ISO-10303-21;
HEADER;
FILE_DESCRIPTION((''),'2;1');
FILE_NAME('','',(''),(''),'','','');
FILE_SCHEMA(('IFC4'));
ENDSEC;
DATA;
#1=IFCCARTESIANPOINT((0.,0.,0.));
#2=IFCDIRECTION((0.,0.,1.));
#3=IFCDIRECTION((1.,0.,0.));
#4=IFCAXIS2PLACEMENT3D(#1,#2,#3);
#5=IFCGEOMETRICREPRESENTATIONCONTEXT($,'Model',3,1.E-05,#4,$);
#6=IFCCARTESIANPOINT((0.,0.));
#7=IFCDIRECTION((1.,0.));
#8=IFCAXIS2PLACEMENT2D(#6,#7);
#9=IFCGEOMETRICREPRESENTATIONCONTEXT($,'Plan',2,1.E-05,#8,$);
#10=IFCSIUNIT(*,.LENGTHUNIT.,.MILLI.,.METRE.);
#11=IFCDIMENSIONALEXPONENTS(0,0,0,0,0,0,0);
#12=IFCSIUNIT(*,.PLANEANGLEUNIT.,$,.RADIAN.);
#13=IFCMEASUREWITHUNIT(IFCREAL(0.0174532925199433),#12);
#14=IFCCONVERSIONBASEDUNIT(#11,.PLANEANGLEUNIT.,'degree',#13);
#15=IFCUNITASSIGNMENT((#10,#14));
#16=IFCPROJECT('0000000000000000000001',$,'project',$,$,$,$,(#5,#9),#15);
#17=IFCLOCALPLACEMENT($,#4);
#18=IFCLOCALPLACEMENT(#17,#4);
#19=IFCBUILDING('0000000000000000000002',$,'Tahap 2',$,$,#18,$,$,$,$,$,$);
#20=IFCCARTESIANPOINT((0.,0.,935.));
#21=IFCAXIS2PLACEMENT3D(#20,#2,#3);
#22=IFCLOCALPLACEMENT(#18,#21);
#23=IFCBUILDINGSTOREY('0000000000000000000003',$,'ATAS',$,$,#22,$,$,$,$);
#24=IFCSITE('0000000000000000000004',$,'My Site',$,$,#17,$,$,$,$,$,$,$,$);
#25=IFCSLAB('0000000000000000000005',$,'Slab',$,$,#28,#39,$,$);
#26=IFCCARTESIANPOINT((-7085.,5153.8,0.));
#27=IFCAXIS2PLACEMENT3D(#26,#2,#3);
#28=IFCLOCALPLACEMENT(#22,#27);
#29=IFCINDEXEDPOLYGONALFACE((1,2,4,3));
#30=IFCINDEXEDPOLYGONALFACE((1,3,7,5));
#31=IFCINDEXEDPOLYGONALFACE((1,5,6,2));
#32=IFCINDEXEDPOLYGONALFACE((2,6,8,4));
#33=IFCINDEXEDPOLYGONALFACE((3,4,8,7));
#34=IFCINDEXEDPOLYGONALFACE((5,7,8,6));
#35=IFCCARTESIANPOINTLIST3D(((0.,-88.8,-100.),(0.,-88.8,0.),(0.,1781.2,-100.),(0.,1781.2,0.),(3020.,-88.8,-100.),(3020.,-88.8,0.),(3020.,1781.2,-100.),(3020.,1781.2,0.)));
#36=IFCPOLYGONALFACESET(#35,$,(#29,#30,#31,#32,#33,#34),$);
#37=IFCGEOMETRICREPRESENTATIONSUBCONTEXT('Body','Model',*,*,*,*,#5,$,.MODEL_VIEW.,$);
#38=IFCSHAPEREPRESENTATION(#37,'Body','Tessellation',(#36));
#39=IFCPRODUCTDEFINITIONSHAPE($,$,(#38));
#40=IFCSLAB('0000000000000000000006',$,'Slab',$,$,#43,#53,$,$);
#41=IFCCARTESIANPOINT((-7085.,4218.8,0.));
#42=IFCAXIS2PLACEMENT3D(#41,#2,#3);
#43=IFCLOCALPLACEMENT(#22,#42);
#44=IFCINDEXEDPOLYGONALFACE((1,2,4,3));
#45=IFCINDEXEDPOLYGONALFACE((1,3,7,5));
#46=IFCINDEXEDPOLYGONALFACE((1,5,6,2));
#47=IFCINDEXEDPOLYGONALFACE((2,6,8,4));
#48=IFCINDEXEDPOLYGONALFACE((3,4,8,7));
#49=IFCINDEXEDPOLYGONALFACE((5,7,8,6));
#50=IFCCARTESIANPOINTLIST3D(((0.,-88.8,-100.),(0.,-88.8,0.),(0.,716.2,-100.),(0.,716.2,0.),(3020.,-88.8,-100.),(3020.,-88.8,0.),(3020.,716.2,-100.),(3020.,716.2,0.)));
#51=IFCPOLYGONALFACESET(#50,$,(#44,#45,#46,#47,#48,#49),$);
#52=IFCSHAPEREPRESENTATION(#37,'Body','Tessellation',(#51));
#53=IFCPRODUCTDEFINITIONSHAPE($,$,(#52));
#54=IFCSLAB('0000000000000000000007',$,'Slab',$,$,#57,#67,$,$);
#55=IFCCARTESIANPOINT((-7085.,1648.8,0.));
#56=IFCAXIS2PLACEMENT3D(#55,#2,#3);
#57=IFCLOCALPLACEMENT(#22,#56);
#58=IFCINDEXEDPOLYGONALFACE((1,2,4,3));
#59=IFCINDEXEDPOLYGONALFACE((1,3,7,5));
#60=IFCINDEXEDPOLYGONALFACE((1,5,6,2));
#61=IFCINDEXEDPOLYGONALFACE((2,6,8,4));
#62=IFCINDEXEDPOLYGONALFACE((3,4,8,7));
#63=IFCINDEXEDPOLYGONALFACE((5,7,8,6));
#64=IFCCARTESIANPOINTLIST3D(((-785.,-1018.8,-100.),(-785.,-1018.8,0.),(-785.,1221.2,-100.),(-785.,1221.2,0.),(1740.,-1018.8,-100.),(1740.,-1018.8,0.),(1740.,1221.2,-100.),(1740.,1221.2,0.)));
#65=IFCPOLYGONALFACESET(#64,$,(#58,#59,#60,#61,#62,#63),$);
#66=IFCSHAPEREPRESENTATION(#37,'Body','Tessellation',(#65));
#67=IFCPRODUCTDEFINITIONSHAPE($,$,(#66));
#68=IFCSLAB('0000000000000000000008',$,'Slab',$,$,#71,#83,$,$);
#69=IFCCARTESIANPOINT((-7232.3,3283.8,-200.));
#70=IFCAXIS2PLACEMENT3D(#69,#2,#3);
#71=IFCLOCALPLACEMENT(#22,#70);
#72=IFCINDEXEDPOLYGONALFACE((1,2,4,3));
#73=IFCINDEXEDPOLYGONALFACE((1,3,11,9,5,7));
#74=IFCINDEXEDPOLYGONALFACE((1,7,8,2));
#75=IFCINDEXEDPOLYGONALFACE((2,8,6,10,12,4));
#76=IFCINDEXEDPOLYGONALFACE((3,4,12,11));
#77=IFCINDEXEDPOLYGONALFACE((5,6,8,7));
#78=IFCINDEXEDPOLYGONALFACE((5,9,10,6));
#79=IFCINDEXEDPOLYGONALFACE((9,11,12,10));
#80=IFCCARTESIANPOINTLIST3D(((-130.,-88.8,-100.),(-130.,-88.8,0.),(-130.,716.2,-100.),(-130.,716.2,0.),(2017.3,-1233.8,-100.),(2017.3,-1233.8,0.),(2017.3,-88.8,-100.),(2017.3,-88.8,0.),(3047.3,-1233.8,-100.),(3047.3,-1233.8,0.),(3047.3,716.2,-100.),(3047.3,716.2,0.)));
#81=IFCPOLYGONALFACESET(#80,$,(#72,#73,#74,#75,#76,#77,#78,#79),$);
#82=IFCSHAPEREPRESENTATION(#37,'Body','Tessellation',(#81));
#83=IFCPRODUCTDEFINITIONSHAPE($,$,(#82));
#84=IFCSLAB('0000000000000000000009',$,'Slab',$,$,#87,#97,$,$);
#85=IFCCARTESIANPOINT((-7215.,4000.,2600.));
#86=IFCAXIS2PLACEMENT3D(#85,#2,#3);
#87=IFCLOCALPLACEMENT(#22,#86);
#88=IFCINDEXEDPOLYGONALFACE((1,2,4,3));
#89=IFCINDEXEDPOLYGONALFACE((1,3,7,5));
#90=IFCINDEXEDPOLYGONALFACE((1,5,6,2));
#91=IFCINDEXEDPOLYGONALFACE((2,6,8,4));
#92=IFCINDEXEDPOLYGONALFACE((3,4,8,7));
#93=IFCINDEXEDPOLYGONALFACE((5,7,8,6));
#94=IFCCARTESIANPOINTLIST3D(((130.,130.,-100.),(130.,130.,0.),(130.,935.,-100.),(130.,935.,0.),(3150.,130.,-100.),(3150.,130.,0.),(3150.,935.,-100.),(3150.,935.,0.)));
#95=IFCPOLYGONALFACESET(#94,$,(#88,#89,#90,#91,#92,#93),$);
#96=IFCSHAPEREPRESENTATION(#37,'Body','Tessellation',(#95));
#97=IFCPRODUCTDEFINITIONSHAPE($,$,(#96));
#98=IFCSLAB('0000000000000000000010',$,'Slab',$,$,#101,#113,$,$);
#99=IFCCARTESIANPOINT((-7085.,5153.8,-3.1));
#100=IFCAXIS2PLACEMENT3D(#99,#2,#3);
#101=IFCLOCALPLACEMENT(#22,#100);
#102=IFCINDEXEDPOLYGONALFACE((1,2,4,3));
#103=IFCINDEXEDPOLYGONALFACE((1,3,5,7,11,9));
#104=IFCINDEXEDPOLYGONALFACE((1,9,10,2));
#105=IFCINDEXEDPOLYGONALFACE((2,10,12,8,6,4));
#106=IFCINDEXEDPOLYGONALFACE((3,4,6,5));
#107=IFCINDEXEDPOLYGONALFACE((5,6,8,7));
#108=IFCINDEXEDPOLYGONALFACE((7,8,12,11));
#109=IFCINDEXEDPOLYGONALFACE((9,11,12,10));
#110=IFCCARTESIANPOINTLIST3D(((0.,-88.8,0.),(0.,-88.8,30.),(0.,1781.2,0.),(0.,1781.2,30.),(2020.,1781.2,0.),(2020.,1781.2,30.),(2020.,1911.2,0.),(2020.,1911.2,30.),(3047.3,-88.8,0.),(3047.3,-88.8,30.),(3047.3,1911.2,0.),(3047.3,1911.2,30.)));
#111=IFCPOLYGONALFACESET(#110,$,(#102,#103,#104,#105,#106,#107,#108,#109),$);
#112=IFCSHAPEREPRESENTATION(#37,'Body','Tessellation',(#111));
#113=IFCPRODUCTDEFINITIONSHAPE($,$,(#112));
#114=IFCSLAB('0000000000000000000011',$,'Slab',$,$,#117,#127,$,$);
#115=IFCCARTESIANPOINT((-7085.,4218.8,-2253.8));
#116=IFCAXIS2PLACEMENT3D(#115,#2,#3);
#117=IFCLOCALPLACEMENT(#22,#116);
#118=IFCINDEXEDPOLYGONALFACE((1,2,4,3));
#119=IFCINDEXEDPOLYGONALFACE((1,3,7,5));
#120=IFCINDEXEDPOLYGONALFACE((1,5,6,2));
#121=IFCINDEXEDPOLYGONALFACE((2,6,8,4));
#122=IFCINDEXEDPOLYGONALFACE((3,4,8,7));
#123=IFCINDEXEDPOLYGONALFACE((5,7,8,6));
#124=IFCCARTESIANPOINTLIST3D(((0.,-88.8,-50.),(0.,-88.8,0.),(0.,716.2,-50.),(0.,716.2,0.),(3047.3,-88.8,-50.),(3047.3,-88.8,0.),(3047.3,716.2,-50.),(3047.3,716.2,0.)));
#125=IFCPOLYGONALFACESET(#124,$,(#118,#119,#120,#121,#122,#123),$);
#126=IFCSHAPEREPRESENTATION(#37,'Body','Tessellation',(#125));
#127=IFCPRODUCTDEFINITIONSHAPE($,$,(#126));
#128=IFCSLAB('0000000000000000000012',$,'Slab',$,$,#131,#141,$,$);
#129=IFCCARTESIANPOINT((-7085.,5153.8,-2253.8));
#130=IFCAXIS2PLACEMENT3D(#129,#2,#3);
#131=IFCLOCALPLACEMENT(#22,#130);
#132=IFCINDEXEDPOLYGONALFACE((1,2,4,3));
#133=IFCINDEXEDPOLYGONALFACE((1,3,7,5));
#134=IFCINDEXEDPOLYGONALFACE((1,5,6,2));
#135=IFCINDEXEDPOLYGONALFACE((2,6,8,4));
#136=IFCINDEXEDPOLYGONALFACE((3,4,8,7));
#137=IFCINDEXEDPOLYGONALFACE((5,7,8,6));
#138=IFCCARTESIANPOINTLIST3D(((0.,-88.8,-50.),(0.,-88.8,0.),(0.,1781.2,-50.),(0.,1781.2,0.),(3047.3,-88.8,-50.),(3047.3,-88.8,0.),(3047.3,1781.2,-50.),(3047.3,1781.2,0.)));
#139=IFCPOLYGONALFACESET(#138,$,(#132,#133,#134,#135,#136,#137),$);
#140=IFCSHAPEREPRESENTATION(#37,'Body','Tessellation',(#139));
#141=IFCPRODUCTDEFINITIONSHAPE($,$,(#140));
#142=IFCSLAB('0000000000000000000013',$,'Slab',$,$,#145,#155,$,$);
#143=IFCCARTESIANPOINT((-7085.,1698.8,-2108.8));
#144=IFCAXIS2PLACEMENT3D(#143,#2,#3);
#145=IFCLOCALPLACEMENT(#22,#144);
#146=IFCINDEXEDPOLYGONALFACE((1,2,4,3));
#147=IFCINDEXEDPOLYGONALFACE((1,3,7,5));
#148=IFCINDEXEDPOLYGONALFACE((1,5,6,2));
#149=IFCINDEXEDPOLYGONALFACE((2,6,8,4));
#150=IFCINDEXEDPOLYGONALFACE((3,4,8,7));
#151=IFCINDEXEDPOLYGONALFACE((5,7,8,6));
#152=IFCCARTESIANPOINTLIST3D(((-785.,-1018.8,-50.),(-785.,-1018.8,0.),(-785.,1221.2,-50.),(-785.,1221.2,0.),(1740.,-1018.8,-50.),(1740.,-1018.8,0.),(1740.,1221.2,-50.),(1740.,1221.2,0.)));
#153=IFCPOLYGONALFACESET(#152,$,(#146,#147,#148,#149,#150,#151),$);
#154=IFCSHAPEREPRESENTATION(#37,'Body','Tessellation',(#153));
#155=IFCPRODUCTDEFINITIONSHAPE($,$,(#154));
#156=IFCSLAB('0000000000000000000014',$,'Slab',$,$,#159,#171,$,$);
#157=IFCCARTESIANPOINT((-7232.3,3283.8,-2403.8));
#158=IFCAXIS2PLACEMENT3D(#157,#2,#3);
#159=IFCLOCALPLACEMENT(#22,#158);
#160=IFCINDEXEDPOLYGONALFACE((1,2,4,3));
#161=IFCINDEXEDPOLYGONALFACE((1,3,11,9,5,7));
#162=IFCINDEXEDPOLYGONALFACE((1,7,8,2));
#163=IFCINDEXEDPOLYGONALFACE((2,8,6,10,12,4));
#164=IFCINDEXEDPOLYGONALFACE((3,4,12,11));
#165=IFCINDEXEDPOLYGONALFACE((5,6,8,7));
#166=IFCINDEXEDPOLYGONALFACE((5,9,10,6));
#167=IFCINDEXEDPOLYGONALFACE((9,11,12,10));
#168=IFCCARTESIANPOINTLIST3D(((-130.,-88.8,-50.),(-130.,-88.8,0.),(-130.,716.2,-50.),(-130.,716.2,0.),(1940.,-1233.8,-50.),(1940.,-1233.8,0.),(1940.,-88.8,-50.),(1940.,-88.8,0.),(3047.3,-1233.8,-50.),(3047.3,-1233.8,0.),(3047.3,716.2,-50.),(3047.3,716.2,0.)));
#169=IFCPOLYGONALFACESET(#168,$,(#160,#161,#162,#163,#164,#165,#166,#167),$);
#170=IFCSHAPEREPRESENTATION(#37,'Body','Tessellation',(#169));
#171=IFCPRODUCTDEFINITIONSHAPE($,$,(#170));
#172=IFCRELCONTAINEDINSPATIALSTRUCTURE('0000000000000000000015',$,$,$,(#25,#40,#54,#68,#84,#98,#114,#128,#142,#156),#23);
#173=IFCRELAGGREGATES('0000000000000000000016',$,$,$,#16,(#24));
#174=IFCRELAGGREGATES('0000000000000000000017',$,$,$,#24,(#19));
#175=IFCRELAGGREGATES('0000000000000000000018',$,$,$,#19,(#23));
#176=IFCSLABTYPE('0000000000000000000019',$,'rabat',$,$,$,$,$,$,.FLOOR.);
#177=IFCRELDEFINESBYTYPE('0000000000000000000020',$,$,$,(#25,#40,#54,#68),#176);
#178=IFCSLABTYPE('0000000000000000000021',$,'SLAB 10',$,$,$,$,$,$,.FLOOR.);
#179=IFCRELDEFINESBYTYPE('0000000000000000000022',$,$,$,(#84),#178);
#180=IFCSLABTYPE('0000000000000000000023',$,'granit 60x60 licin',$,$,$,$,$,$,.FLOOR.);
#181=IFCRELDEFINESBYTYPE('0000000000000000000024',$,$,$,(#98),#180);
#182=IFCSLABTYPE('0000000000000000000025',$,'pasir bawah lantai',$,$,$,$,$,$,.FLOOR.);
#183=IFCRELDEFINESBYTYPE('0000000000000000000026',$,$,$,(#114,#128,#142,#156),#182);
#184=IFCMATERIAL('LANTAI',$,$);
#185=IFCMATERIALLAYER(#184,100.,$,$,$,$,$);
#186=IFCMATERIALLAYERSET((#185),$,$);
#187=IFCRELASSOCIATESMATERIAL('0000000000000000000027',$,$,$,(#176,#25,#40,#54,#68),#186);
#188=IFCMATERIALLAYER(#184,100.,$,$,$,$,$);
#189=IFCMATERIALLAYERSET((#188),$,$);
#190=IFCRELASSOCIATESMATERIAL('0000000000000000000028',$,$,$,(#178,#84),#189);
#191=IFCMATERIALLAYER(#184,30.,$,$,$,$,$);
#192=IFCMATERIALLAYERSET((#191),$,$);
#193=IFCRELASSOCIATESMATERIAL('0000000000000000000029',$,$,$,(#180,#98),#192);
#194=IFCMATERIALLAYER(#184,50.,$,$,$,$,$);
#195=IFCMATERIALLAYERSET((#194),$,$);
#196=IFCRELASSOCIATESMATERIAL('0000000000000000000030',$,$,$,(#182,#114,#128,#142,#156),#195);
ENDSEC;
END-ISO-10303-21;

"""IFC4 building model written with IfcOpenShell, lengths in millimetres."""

from ifc_helpers import new_model, entity, si_unit, converted_unit, frame, origin_with_axes, origin_2d_with_axis, place, context, subcontext, project, spatial, indexed_curve, outline, extrude, material, layer, layer_set, layer_usage, type_object, element, save


model = new_model("IFC4")

# Units and contexts
model_context = context("Model", 3, precision=1e-05, world=origin_with_axes())
plan_context = context("Plan", 2, precision=1e-05, world=origin_2d_with_axis())
body_context_1 = subcontext(model_context, "Body", "Model", "MODEL_VIEW")
ifc_project = project(units=[si_unit("LENGTHUNIT", "METRE", prefix="MILLI"), converted_unit("PLANEANGLEUNIT", "degree", entity("IfcReal", 0.0174532925199433), si_unit("PLANEANGLEUNIT", "RADIAN"), dimensions=[0, 0, 0, 0, 0, 0, 0])], contexts=[model_context, plan_context])

# Site, building, storey
site_placement = place(None, origin_with_axes())
site = spatial("IfcSite", under=ifc_project, at=site_placement, Name="My Site")
building_placement = place(site_placement, origin_with_axes())
building = spatial("IfcBuilding", under=site, at=building_placement, Name="Tahap 2")
storey_placement = place(building_placement, frame((0.0, 0.0, 935.0), z_axis=(0.0, 0.0, 1.0), x_axis=(1.0, 0.0, 0.0)))
storey = spatial("IfcBuildingStorey", under=building, at=storey_placement, Name="ATAS")

# Slabs
ifc_material_1 = material(Name="LANTAI")
ifc_layer_1 = layer(ifc_material_1, 100.0)
ifc_layer_set_1 = layer_set([ifc_layer_1])
ifc_layer_usage_1 = layer_usage(ifc_layer_set_1, "AXIS3", "NEGATIVE", 0.0)
slab_type_1 = type_object("IfcSlabType", Name="rabat", PredefinedType="FLOOR", material=ifc_layer_set_1)
slab_1_placement = place(storey_placement, frame((-7085.0, 5153.8, 0.0), z_axis=(0.0, 0.0, 1.0), x_axis=(1.0, 0.0, 0.0)))
element("IfcSlab", 1, at=slab_1_placement, inside=storey, type_object=slab_type_1, material=ifc_layer_usage_1, Name="Slab", context=body_context_1, shape_type="SweptSolid", body=[
    extrude(outline(indexed_curve([(0.0, -88.8), (3020.0, -88.8), (3020.0, 1781.2), (0.0, 1781.2), (0.0, -88.8)])), None, (0.0, 0.0, -1.0), 100.0),
])
ifc_layer_usage_2 = layer_usage(ifc_layer_set_1, "AXIS3", "NEGATIVE", 0.0)
slab_2_placement = place(storey_placement, frame((-7085.0, 4218.8, 0.0), z_axis=(0.0, 0.0, 1.0), x_axis=(1.0, 0.0, 0.0)))
element("IfcSlab", 2, at=slab_2_placement, inside=storey, type_object=slab_type_1, material=ifc_layer_usage_2, Name="Slab", context=body_context_1, shape_type="SweptSolid", body=[
    extrude(outline(indexed_curve([(3020.0, 716.2), (0.0, 716.2), (0.0, -88.8), (3020.0, -88.8), (3020.0, 716.2)])), None, (0.0, 0.0, -1.0), 100.0),
])
ifc_layer_usage_3 = layer_usage(ifc_layer_set_1, "AXIS3", "NEGATIVE", 0.0)
slab_3_placement = place(storey_placement, frame((-7085.0, 1648.8, 0.0), z_axis=(0.0, 0.0, 1.0), x_axis=(1.0, 0.0, 0.0)))
element("IfcSlab", 3, at=slab_3_placement, inside=storey, type_object=slab_type_1, material=ifc_layer_usage_3, Name="Slab", context=body_context_1, shape_type="SweptSolid", body=[
    extrude(outline(indexed_curve([(-785.0, 1221.2), (1740.0, 1221.2), (1740.0, -1018.8), (-785.0, -1018.8), (-785.0, 1221.2)])), None, (0.0, 0.0, -1.0), 100.0),
])
ifc_layer_usage_4 = layer_usage(ifc_layer_set_1, "AXIS3", "NEGATIVE", 0.0)
slab_4_placement = place(storey_placement, frame((-7232.3, 3283.8, -200.0), z_axis=(0.0, 0.0, 1.0), x_axis=(1.0, 0.0, 0.0)))
element("IfcSlab", 4, at=slab_4_placement, inside=storey, type_object=slab_type_1, material=ifc_layer_usage_4, Name="Slab", context=body_context_1, shape_type="SweptSolid", body=[
    extrude(outline(indexed_curve([(3047.3, -1233.8), (3047.3, 716.2), (-130.0, 716.2), (-130.0, -88.8), (2017.3, -88.8), (2017.3, -1233.8), (3047.3, -1233.8)])), None, (0.0, 0.0, -1.0), 100.0),
])
ifc_layer_2 = layer(ifc_material_1, 100.0)
ifc_layer_set_2 = layer_set([ifc_layer_2])
ifc_layer_usage_5 = layer_usage(ifc_layer_set_2, "AXIS3", "NEGATIVE", 0.0)
slab_type_2 = type_object("IfcSlabType", Name="SLAB 10", PredefinedType="FLOOR", material=ifc_layer_set_2)
slab_5_placement = place(storey_placement, frame((-7215.0, 4000.0, 2600.0), z_axis=(0.0, 0.0, 1.0), x_axis=(1.0, 0.0, 0.0)))
element("IfcSlab", 5, at=slab_5_placement, inside=storey, type_object=slab_type_2, material=ifc_layer_usage_5, Name="Slab", context=body_context_1, shape_type="SweptSolid", body=[
    extrude(outline(indexed_curve([(130.0, 935.0), (3150.0, 935.0), (3150.0, 130.0), (130.0, 130.0), (130.0, 935.0)])), None, (0.0, 0.0, -1.0), 100.0),
])
ifc_layer_3 = layer(ifc_material_1, 30.0)
ifc_layer_set_3 = layer_set([ifc_layer_3])
ifc_layer_usage_6 = layer_usage(ifc_layer_set_3, "AXIS3", "POSITIVE", 0.0)
slab_type_3 = type_object("IfcSlabType", Name="granit 60x60 licin", PredefinedType="FLOOR", material=ifc_layer_set_3)
slab_6_placement = place(storey_placement, frame((-7085.0, 5153.8, -3.1), z_axis=(0.0, 0.0, 1.0), x_axis=(1.0, 0.0, 0.0)))
element("IfcSlab", 6, at=slab_6_placement, inside=storey, type_object=slab_type_3, material=ifc_layer_usage_6, Name="Slab", context=body_context_1, shape_type="SweptSolid", body=[
    extrude(outline(indexed_curve([(2020.0, 1781.2), (2020.0, 1911.2), (3047.3, 1911.2), (3047.3, -88.8), (0.0, -88.8), (0.0, 1781.2), (2020.0, 1781.2)])), None, (0.0, 0.0, 1.0), 30.0),
])
ifc_layer_4 = layer(ifc_material_1, 50.0)
ifc_layer_set_4 = layer_set([ifc_layer_4])
ifc_layer_usage_7 = layer_usage(ifc_layer_set_4, "AXIS3", "POSITIVE", -50.0)
slab_type_4 = type_object("IfcSlabType", Name="pasir bawah lantai", PredefinedType="FLOOR", material=ifc_layer_set_4)
slab_7_placement = place(storey_placement, frame((-7085.0, 4218.8, -2253.8), z_axis=(0.0, 0.0, 1.0), x_axis=(1.0, 0.0, 0.0)))
element("IfcSlab", 7, at=slab_7_placement, inside=storey, type_object=slab_type_4, material=ifc_layer_usage_7, Name="Slab", context=body_context_1, shape_type="SweptSolid", body=[
    extrude(outline(indexed_curve([(3047.3, -88.8), (0.0, -88.8), (0.0, 716.2), (3047.3, 716.2), (3047.3, -88.8)])), frame((0.0, 0.0, -50.0), z_axis=(0.0, 0.0, 1.0), x_axis=(1.0, 0.0, 0.0)), (0.0, 0.0, 1.0), 50.0),
])
ifc_layer_usage_8 = layer_usage(ifc_layer_set_4, "AXIS3", "POSITIVE", -50.0)
slab_8_placement = place(storey_placement, frame((-7085.0, 5153.8, -2253.8), z_axis=(0.0, 0.0, 1.0), x_axis=(1.0, 0.0, 0.0)))
element("IfcSlab", 8, at=slab_8_placement, inside=storey, type_object=slab_type_4, material=ifc_layer_usage_8, Name="Slab", context=body_context_1, shape_type="SweptSolid", body=[
    extrude(outline(indexed_curve([(0.0, -88.8), (3047.3, -88.8), (3047.3, 1781.2), (0.0, 1781.2), (0.0, -88.8)])), frame((0.0, 0.0, -50.0), z_axis=(0.0, 0.0, 1.0), x_axis=(1.0, 0.0, 0.0)), (0.0, 0.0, 1.0), 50.0),
])
ifc_layer_usage_9 = layer_usage(ifc_layer_set_4, "AXIS3", "POSITIVE", -50.0)
slab_9_placement = place(storey_placement, frame((-7085.0, 1698.8, -2108.8), z_axis=(0.0, 0.0, 1.0), x_axis=(1.0, 0.0, 0.0)))
element("IfcSlab", 9, at=slab_9_placement, inside=storey, type_object=slab_type_4, material=ifc_layer_usage_9, Name="Slab", context=body_context_1, shape_type="SweptSolid", body=[
    extrude(outline(indexed_curve([(-785.0, 1221.2), (1740.0, 1221.2), (1740.0, -1018.8), (-785.0, -1018.8), (-785.0, 1221.2)])), frame((0.0, 0.0, -50.0), z_axis=(0.0, 0.0, 1.0), x_axis=(1.0, 0.0, 0.0)), (0.0, 0.0, 1.0), 50.0),
])
ifc_layer_usage_10 = layer_usage(ifc_layer_set_4, "AXIS3", "POSITIVE", -50.0)
slab_10_placement = place(storey_placement, frame((-7232.3, 3283.8, -2403.8), z_axis=(0.0, 0.0, 1.0), x_axis=(1.0, 0.0, 0.0)))
element("IfcSlab", 10, at=slab_10_placement, inside=storey, type_object=slab_type_4, material=ifc_layer_usage_10, Name="Slab", context=body_context_1, shape_type="SweptSolid", body=[
    extrude(outline(indexed_curve([(1940.0, -1233.8), (1940.0, -88.8), (-130.0, -88.8), (-130.0, 716.2), (3047.3, 716.2), (3047.3, -1233.8), (1940.0, -1233.8)])), frame((0.0, 0.0, -50.0), z_axis=(0.0, 0.0, 1.0), x_axis=(1.0, 0.0, 0.0)), (0.0, 0.0, 1.0), 50.0),
])

save(model, "model.ifc")
